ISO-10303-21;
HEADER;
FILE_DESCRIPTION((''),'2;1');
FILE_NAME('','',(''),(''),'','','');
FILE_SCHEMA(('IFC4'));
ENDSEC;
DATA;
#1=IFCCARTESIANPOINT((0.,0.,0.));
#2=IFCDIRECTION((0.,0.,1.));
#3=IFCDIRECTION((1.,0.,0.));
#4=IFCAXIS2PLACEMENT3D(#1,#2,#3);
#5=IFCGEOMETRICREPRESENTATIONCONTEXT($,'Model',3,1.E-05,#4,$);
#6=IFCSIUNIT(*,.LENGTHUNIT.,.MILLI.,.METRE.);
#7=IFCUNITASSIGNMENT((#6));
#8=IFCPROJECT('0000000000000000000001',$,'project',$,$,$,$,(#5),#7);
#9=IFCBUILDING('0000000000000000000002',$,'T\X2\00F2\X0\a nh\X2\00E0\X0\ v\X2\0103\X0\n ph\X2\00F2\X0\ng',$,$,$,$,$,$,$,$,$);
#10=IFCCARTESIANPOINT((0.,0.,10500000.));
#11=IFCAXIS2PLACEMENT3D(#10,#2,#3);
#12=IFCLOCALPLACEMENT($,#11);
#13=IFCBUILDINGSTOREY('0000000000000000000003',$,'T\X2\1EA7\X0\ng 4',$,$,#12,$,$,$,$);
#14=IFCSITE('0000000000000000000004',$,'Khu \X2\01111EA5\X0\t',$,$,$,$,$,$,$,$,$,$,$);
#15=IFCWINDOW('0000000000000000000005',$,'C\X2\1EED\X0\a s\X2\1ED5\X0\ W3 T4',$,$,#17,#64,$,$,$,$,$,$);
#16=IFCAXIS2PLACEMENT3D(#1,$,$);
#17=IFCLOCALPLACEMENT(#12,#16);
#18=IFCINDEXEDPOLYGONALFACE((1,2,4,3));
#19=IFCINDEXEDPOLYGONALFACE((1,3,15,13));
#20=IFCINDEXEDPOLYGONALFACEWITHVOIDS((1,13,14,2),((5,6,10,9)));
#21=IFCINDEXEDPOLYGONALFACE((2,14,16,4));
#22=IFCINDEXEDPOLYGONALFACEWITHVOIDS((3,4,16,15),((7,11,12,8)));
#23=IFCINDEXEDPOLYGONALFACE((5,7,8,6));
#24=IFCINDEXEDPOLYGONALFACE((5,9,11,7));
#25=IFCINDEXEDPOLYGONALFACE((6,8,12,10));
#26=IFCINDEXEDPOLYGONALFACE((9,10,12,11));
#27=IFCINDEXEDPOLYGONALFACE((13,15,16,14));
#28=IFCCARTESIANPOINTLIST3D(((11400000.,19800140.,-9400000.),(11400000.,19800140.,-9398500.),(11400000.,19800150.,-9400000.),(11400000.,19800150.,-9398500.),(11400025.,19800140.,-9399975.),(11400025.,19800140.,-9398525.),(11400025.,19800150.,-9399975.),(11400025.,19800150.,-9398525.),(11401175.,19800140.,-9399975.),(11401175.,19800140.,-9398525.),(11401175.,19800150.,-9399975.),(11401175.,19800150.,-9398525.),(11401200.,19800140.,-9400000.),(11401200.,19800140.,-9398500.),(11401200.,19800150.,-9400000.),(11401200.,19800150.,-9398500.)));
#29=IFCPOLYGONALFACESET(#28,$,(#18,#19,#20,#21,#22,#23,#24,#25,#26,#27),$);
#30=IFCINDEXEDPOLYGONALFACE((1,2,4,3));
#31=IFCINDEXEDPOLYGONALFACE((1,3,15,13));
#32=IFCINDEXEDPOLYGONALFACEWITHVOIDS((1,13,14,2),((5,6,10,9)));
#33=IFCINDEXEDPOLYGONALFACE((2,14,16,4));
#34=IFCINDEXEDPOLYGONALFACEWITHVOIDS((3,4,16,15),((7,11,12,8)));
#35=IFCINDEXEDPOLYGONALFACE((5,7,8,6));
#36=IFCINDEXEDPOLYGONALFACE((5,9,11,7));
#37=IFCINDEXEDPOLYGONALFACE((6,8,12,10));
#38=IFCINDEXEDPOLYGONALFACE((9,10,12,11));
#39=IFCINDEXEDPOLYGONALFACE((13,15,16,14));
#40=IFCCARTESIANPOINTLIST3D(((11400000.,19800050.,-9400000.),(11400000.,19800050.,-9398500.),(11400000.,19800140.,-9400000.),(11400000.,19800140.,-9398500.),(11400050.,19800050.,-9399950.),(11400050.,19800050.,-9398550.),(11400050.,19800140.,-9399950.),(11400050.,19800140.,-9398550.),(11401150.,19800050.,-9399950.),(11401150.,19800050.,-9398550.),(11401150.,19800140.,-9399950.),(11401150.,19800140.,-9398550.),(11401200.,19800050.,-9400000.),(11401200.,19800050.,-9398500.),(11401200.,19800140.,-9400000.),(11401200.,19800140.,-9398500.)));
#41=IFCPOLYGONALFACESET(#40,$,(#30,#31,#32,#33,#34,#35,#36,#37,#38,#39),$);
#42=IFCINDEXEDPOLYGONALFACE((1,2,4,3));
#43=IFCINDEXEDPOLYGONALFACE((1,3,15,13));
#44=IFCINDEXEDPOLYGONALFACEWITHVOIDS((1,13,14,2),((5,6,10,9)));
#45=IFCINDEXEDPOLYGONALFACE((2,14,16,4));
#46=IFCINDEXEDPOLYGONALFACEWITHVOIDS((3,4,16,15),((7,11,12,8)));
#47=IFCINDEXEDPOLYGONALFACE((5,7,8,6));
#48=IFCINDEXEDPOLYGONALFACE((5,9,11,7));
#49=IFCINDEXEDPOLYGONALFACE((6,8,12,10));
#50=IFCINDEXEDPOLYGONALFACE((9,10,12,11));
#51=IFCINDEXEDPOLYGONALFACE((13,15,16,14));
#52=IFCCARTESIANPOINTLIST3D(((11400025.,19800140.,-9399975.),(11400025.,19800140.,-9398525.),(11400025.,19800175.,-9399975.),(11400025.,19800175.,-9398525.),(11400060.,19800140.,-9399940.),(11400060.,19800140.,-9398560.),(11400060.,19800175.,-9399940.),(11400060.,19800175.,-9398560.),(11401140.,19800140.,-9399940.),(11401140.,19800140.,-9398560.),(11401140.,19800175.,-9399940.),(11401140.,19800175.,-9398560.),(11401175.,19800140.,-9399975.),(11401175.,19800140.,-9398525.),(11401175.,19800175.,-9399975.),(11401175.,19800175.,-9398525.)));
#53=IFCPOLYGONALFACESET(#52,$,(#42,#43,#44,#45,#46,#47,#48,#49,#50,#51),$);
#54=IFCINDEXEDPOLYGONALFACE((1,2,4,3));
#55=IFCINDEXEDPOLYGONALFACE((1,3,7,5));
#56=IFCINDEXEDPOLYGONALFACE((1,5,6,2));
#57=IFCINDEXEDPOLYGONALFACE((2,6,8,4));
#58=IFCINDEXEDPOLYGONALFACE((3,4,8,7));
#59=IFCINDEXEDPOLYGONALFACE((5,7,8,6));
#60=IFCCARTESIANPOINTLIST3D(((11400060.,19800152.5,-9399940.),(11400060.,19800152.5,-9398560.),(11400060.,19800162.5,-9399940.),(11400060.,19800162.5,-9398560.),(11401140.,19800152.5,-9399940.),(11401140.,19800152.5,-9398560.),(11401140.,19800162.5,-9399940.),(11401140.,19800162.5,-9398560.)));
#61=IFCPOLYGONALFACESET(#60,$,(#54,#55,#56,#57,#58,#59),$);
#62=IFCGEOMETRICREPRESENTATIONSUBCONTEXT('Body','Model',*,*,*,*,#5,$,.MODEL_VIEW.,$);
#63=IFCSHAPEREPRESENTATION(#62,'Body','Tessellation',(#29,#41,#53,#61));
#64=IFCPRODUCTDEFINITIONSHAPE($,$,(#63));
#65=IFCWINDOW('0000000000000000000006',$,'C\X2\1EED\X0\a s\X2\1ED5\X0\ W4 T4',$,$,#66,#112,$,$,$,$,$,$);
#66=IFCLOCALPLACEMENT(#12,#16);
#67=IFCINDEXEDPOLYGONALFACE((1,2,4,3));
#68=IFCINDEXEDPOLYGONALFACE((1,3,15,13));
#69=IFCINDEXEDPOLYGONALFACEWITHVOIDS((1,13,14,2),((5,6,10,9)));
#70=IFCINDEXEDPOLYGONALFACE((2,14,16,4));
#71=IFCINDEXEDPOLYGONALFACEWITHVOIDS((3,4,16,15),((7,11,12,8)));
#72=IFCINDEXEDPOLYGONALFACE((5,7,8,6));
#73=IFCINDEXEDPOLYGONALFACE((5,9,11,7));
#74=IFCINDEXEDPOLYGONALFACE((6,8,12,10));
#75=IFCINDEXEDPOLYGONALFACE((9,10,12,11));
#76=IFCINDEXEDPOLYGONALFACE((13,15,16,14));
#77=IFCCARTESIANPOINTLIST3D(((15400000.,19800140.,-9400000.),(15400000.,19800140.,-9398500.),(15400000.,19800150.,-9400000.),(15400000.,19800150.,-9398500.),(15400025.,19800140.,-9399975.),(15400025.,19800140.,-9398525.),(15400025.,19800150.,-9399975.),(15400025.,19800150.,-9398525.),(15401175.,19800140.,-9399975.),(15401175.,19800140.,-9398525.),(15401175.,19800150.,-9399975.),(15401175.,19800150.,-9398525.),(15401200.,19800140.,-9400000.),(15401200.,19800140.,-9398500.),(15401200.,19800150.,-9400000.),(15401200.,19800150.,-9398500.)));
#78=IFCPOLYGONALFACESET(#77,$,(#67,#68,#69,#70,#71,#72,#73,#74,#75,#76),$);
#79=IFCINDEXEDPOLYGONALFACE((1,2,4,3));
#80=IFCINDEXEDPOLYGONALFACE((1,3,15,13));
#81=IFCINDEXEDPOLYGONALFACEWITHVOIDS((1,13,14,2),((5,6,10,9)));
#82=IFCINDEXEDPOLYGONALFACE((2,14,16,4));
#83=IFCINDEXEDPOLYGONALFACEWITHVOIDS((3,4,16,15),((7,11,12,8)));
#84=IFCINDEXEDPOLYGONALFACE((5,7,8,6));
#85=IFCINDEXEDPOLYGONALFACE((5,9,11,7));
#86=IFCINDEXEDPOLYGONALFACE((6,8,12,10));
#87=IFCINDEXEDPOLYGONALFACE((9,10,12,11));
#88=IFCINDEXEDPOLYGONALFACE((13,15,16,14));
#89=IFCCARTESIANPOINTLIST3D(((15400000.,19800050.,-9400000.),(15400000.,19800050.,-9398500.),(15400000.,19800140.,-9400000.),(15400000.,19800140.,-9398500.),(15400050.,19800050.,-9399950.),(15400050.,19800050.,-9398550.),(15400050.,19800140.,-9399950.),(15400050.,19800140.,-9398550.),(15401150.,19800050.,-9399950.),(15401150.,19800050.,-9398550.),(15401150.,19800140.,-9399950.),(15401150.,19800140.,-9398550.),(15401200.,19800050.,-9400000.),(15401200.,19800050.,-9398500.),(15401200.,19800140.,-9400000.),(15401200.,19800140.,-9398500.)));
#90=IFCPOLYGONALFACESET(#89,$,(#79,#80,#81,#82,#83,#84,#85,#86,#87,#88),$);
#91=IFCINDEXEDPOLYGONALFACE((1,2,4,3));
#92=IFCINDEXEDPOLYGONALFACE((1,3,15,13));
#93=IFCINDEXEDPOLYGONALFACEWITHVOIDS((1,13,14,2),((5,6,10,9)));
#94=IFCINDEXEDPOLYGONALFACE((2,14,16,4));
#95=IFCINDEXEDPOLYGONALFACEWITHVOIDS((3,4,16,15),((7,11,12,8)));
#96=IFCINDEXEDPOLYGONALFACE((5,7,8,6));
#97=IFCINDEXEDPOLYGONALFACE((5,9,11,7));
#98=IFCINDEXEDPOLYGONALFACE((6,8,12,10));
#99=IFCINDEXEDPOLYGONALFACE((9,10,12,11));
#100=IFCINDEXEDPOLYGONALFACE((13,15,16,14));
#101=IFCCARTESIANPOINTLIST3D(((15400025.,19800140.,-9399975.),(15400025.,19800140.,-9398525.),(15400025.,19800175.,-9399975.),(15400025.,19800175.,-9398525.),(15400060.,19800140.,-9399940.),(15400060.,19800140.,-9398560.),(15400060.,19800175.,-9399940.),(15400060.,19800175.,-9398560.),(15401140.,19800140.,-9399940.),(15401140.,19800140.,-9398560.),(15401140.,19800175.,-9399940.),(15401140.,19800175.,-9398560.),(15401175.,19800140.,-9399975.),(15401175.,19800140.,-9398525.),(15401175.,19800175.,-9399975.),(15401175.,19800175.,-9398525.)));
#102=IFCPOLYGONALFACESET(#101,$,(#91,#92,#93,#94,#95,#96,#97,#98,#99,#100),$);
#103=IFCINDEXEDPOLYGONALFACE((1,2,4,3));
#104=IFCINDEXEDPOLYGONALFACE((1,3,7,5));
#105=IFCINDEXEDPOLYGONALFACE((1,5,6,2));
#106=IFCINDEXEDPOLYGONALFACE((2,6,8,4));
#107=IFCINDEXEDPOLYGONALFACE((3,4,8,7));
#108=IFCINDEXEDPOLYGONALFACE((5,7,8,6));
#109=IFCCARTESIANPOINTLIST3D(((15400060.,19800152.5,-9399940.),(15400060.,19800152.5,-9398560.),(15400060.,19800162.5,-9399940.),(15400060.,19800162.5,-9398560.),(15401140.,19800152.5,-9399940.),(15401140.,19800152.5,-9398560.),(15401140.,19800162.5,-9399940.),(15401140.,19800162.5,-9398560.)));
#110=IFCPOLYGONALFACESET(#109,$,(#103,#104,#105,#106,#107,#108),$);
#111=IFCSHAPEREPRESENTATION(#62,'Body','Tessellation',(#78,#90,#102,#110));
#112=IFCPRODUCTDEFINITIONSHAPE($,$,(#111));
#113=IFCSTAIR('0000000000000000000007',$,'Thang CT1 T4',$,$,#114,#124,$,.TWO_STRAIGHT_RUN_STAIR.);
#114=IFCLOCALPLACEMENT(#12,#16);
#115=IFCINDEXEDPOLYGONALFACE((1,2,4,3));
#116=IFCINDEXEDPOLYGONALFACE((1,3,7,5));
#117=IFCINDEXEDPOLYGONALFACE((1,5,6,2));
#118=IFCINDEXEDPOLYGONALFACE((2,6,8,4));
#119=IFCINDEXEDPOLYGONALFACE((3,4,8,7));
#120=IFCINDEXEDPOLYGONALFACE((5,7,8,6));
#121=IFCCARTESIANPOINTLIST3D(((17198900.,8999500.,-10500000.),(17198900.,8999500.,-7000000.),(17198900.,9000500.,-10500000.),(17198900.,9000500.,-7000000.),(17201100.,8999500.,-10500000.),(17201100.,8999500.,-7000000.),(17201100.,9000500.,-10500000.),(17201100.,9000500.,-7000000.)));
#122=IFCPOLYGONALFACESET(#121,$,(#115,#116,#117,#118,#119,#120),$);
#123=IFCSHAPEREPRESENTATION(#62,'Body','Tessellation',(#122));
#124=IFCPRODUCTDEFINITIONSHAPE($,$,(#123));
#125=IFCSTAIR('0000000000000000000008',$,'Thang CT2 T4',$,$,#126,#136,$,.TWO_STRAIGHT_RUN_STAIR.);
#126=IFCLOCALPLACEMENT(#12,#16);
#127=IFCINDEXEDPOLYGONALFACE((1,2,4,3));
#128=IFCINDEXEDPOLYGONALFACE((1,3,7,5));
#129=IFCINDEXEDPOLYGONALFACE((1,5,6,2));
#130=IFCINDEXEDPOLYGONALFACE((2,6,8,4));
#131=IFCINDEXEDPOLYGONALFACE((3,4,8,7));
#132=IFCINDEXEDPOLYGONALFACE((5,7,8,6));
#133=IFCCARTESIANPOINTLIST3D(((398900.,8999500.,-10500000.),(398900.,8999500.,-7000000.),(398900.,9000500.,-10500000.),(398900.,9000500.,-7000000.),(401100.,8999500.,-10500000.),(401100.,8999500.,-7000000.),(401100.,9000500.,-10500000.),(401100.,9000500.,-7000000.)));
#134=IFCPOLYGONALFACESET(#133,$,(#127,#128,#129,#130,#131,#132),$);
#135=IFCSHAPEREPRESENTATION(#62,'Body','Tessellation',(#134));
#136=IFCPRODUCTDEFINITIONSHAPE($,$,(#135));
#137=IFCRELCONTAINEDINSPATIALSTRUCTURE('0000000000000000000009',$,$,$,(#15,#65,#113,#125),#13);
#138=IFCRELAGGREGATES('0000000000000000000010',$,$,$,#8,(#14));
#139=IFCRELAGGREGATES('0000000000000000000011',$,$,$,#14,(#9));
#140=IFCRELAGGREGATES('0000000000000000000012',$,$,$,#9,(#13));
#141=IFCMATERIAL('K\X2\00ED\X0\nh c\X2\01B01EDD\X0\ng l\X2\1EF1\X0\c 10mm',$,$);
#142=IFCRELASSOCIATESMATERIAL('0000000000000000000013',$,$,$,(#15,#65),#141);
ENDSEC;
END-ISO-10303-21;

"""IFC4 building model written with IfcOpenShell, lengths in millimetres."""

from ifc_helpers import new_model, entity, si_unit, frame, origin_with_axes, place, context, subcontext, project, spatial, line, indexed_curve, outline, extrude, material, element, save


model = new_model("IFC4")

# Units and contexts
model_context = context("Model", 3, precision=1e-05, world=origin_with_axes())
body_context = subcontext(model_context, "Body", "Model", "MODEL_VIEW")
ifc_project = project(units=[si_unit("LENGTHUNIT", "METRE", prefix="MILLI")], contexts=[model_context])

# Site, building, storey
site = spatial("IfcSite", under=ifc_project, Name="Khu đất")
building = spatial("IfcBuilding", under=site, Name="Tòa nhà văn phòng")
storey_placement = place(None, frame((0.0, 0.0, 10500000.0), z_axis=(0.0, 0.0, 1.0), x_axis=(1.0, 0.0, 0.0)))
storey = spatial("IfcBuildingStorey", under=building, at=storey_placement, Name="Tầng 4")

# Windows
ifc_material_1 = material(Name="Kính cường lực 10mm")
for number, where, z_axis, x_axis, name in (
    (1, (11400000.0, 19800000.0, -9400000.0), (0.0, 0.0, 1.0), (1.0, 0.0, 0.0), "Cửa sổ W3 T4"),
    (2, (15400000.0, 19800000.0, -9400000.0), (0.0, 0.0, 1.0), (1.0, 0.0, 0.0), "Cửa sổ W4 T4"),
):
    element("IfcWindow", number, at=place(storey_placement, frame(where, z_axis=z_axis, x_axis=x_axis)), inside=storey, material=ifc_material_1, Name=name, context=body_context, shape_type="SolidModel", body=[
        extrude(outline(indexed_curve([(0.0, 0.0), (1200.0, 0.0), (1200.0, 1500.0), (0.0, 1500.0)], segments=[line(1, 2, 3, 4, 1)]), holes=[indexed_curve([(25.0, 25.0), (1175.0, 25.0), (1175.0, 1475.0), (25.0, 1475.0)], segments=[line(1, 2, 3, 4, 1)])]), frame((0.0, 140.0, 0.0), z_axis=(0.0, -1.0, 0.0), x_axis=(1.0, 0.0, 0.0)), (0.0, 0.0, -1.0), 10.0),
        extrude(outline(indexed_curve([(0.0, 0.0), (1200.0, 0.0), (1200.0, 1500.0), (0.0, 1500.0)], segments=[line(1, 2, 3, 4, 1)]), holes=[indexed_curve([(50.0, 50.0), (1150.0, 50.0), (1150.0, 1450.0), (50.0, 1450.0)], segments=[line(1, 2, 3, 4, 1)])]), frame((0.0, 50.0, 0.0), z_axis=(0.0, -1.0, 0.0), x_axis=(1.0, 0.0, 0.0)), (0.0, 0.0, -1.0), 90.0),
        extrude(outline(indexed_curve([(0.0, 0.0), (1150.0, 0.0), (1150.0, 1450.0), (0.0, 1450.0)], segments=[line(1, 2, 3, 4, 1)]), holes=[indexed_curve([(35.0, 35.0), (1115.0, 35.0), (1115.0, 1415.0), (35.0, 1415.0)], segments=[line(1, 2, 3, 4, 1)])]), frame((25.0, 140.0, 25.0), z_axis=(0.0, -1.0, 0.0), x_axis=(1.0, 0.0, 0.0)), (0.0, 0.0, -1.0), 35.0),
        extrude(outline(indexed_curve([(35.0, 35.0), (1115.0, 35.0), (1115.0, 1415.0), (35.0, 1415.0)], segments=[line(1, 2, 3, 4, 1)])), frame((25.0, 152.5, 25.0), z_axis=(0.0, -1.0, 0.0), x_axis=(1.0, 0.0, 0.0)), (0.0, 0.0, -1.0), 10.0),
    ])

# Stairs
for number, where, z_axis, x_axis, name in (
    (3, (17200000.0, 9000000.0, -10500000.0), (0.0, 0.0, 1.0), (1.0, 0.0, 0.0), "Thang CT1 T4"),
    (4, (400000.0, 9000000.0, -10500000.0), (0.0, 0.0, 1.0), (1.0, 0.0, 0.0), "Thang CT2 T4"),
):
    element("IfcStair", number, at=place(storey_placement, frame(where, z_axis=z_axis, x_axis=x_axis)), inside=storey, Name=name, PredefinedType="TWO_STRAIGHT_RUN_STAIR", context=body_context, shape_type="SweptSolid", body=[
        extrude(entity("IfcRectangleProfileDef", None, None, None, 2200.0, 1000.0), origin_with_axes(), (0.0, 0.0, 1.0), 3500000.0),
    ])

save(model, "model.ifc")
